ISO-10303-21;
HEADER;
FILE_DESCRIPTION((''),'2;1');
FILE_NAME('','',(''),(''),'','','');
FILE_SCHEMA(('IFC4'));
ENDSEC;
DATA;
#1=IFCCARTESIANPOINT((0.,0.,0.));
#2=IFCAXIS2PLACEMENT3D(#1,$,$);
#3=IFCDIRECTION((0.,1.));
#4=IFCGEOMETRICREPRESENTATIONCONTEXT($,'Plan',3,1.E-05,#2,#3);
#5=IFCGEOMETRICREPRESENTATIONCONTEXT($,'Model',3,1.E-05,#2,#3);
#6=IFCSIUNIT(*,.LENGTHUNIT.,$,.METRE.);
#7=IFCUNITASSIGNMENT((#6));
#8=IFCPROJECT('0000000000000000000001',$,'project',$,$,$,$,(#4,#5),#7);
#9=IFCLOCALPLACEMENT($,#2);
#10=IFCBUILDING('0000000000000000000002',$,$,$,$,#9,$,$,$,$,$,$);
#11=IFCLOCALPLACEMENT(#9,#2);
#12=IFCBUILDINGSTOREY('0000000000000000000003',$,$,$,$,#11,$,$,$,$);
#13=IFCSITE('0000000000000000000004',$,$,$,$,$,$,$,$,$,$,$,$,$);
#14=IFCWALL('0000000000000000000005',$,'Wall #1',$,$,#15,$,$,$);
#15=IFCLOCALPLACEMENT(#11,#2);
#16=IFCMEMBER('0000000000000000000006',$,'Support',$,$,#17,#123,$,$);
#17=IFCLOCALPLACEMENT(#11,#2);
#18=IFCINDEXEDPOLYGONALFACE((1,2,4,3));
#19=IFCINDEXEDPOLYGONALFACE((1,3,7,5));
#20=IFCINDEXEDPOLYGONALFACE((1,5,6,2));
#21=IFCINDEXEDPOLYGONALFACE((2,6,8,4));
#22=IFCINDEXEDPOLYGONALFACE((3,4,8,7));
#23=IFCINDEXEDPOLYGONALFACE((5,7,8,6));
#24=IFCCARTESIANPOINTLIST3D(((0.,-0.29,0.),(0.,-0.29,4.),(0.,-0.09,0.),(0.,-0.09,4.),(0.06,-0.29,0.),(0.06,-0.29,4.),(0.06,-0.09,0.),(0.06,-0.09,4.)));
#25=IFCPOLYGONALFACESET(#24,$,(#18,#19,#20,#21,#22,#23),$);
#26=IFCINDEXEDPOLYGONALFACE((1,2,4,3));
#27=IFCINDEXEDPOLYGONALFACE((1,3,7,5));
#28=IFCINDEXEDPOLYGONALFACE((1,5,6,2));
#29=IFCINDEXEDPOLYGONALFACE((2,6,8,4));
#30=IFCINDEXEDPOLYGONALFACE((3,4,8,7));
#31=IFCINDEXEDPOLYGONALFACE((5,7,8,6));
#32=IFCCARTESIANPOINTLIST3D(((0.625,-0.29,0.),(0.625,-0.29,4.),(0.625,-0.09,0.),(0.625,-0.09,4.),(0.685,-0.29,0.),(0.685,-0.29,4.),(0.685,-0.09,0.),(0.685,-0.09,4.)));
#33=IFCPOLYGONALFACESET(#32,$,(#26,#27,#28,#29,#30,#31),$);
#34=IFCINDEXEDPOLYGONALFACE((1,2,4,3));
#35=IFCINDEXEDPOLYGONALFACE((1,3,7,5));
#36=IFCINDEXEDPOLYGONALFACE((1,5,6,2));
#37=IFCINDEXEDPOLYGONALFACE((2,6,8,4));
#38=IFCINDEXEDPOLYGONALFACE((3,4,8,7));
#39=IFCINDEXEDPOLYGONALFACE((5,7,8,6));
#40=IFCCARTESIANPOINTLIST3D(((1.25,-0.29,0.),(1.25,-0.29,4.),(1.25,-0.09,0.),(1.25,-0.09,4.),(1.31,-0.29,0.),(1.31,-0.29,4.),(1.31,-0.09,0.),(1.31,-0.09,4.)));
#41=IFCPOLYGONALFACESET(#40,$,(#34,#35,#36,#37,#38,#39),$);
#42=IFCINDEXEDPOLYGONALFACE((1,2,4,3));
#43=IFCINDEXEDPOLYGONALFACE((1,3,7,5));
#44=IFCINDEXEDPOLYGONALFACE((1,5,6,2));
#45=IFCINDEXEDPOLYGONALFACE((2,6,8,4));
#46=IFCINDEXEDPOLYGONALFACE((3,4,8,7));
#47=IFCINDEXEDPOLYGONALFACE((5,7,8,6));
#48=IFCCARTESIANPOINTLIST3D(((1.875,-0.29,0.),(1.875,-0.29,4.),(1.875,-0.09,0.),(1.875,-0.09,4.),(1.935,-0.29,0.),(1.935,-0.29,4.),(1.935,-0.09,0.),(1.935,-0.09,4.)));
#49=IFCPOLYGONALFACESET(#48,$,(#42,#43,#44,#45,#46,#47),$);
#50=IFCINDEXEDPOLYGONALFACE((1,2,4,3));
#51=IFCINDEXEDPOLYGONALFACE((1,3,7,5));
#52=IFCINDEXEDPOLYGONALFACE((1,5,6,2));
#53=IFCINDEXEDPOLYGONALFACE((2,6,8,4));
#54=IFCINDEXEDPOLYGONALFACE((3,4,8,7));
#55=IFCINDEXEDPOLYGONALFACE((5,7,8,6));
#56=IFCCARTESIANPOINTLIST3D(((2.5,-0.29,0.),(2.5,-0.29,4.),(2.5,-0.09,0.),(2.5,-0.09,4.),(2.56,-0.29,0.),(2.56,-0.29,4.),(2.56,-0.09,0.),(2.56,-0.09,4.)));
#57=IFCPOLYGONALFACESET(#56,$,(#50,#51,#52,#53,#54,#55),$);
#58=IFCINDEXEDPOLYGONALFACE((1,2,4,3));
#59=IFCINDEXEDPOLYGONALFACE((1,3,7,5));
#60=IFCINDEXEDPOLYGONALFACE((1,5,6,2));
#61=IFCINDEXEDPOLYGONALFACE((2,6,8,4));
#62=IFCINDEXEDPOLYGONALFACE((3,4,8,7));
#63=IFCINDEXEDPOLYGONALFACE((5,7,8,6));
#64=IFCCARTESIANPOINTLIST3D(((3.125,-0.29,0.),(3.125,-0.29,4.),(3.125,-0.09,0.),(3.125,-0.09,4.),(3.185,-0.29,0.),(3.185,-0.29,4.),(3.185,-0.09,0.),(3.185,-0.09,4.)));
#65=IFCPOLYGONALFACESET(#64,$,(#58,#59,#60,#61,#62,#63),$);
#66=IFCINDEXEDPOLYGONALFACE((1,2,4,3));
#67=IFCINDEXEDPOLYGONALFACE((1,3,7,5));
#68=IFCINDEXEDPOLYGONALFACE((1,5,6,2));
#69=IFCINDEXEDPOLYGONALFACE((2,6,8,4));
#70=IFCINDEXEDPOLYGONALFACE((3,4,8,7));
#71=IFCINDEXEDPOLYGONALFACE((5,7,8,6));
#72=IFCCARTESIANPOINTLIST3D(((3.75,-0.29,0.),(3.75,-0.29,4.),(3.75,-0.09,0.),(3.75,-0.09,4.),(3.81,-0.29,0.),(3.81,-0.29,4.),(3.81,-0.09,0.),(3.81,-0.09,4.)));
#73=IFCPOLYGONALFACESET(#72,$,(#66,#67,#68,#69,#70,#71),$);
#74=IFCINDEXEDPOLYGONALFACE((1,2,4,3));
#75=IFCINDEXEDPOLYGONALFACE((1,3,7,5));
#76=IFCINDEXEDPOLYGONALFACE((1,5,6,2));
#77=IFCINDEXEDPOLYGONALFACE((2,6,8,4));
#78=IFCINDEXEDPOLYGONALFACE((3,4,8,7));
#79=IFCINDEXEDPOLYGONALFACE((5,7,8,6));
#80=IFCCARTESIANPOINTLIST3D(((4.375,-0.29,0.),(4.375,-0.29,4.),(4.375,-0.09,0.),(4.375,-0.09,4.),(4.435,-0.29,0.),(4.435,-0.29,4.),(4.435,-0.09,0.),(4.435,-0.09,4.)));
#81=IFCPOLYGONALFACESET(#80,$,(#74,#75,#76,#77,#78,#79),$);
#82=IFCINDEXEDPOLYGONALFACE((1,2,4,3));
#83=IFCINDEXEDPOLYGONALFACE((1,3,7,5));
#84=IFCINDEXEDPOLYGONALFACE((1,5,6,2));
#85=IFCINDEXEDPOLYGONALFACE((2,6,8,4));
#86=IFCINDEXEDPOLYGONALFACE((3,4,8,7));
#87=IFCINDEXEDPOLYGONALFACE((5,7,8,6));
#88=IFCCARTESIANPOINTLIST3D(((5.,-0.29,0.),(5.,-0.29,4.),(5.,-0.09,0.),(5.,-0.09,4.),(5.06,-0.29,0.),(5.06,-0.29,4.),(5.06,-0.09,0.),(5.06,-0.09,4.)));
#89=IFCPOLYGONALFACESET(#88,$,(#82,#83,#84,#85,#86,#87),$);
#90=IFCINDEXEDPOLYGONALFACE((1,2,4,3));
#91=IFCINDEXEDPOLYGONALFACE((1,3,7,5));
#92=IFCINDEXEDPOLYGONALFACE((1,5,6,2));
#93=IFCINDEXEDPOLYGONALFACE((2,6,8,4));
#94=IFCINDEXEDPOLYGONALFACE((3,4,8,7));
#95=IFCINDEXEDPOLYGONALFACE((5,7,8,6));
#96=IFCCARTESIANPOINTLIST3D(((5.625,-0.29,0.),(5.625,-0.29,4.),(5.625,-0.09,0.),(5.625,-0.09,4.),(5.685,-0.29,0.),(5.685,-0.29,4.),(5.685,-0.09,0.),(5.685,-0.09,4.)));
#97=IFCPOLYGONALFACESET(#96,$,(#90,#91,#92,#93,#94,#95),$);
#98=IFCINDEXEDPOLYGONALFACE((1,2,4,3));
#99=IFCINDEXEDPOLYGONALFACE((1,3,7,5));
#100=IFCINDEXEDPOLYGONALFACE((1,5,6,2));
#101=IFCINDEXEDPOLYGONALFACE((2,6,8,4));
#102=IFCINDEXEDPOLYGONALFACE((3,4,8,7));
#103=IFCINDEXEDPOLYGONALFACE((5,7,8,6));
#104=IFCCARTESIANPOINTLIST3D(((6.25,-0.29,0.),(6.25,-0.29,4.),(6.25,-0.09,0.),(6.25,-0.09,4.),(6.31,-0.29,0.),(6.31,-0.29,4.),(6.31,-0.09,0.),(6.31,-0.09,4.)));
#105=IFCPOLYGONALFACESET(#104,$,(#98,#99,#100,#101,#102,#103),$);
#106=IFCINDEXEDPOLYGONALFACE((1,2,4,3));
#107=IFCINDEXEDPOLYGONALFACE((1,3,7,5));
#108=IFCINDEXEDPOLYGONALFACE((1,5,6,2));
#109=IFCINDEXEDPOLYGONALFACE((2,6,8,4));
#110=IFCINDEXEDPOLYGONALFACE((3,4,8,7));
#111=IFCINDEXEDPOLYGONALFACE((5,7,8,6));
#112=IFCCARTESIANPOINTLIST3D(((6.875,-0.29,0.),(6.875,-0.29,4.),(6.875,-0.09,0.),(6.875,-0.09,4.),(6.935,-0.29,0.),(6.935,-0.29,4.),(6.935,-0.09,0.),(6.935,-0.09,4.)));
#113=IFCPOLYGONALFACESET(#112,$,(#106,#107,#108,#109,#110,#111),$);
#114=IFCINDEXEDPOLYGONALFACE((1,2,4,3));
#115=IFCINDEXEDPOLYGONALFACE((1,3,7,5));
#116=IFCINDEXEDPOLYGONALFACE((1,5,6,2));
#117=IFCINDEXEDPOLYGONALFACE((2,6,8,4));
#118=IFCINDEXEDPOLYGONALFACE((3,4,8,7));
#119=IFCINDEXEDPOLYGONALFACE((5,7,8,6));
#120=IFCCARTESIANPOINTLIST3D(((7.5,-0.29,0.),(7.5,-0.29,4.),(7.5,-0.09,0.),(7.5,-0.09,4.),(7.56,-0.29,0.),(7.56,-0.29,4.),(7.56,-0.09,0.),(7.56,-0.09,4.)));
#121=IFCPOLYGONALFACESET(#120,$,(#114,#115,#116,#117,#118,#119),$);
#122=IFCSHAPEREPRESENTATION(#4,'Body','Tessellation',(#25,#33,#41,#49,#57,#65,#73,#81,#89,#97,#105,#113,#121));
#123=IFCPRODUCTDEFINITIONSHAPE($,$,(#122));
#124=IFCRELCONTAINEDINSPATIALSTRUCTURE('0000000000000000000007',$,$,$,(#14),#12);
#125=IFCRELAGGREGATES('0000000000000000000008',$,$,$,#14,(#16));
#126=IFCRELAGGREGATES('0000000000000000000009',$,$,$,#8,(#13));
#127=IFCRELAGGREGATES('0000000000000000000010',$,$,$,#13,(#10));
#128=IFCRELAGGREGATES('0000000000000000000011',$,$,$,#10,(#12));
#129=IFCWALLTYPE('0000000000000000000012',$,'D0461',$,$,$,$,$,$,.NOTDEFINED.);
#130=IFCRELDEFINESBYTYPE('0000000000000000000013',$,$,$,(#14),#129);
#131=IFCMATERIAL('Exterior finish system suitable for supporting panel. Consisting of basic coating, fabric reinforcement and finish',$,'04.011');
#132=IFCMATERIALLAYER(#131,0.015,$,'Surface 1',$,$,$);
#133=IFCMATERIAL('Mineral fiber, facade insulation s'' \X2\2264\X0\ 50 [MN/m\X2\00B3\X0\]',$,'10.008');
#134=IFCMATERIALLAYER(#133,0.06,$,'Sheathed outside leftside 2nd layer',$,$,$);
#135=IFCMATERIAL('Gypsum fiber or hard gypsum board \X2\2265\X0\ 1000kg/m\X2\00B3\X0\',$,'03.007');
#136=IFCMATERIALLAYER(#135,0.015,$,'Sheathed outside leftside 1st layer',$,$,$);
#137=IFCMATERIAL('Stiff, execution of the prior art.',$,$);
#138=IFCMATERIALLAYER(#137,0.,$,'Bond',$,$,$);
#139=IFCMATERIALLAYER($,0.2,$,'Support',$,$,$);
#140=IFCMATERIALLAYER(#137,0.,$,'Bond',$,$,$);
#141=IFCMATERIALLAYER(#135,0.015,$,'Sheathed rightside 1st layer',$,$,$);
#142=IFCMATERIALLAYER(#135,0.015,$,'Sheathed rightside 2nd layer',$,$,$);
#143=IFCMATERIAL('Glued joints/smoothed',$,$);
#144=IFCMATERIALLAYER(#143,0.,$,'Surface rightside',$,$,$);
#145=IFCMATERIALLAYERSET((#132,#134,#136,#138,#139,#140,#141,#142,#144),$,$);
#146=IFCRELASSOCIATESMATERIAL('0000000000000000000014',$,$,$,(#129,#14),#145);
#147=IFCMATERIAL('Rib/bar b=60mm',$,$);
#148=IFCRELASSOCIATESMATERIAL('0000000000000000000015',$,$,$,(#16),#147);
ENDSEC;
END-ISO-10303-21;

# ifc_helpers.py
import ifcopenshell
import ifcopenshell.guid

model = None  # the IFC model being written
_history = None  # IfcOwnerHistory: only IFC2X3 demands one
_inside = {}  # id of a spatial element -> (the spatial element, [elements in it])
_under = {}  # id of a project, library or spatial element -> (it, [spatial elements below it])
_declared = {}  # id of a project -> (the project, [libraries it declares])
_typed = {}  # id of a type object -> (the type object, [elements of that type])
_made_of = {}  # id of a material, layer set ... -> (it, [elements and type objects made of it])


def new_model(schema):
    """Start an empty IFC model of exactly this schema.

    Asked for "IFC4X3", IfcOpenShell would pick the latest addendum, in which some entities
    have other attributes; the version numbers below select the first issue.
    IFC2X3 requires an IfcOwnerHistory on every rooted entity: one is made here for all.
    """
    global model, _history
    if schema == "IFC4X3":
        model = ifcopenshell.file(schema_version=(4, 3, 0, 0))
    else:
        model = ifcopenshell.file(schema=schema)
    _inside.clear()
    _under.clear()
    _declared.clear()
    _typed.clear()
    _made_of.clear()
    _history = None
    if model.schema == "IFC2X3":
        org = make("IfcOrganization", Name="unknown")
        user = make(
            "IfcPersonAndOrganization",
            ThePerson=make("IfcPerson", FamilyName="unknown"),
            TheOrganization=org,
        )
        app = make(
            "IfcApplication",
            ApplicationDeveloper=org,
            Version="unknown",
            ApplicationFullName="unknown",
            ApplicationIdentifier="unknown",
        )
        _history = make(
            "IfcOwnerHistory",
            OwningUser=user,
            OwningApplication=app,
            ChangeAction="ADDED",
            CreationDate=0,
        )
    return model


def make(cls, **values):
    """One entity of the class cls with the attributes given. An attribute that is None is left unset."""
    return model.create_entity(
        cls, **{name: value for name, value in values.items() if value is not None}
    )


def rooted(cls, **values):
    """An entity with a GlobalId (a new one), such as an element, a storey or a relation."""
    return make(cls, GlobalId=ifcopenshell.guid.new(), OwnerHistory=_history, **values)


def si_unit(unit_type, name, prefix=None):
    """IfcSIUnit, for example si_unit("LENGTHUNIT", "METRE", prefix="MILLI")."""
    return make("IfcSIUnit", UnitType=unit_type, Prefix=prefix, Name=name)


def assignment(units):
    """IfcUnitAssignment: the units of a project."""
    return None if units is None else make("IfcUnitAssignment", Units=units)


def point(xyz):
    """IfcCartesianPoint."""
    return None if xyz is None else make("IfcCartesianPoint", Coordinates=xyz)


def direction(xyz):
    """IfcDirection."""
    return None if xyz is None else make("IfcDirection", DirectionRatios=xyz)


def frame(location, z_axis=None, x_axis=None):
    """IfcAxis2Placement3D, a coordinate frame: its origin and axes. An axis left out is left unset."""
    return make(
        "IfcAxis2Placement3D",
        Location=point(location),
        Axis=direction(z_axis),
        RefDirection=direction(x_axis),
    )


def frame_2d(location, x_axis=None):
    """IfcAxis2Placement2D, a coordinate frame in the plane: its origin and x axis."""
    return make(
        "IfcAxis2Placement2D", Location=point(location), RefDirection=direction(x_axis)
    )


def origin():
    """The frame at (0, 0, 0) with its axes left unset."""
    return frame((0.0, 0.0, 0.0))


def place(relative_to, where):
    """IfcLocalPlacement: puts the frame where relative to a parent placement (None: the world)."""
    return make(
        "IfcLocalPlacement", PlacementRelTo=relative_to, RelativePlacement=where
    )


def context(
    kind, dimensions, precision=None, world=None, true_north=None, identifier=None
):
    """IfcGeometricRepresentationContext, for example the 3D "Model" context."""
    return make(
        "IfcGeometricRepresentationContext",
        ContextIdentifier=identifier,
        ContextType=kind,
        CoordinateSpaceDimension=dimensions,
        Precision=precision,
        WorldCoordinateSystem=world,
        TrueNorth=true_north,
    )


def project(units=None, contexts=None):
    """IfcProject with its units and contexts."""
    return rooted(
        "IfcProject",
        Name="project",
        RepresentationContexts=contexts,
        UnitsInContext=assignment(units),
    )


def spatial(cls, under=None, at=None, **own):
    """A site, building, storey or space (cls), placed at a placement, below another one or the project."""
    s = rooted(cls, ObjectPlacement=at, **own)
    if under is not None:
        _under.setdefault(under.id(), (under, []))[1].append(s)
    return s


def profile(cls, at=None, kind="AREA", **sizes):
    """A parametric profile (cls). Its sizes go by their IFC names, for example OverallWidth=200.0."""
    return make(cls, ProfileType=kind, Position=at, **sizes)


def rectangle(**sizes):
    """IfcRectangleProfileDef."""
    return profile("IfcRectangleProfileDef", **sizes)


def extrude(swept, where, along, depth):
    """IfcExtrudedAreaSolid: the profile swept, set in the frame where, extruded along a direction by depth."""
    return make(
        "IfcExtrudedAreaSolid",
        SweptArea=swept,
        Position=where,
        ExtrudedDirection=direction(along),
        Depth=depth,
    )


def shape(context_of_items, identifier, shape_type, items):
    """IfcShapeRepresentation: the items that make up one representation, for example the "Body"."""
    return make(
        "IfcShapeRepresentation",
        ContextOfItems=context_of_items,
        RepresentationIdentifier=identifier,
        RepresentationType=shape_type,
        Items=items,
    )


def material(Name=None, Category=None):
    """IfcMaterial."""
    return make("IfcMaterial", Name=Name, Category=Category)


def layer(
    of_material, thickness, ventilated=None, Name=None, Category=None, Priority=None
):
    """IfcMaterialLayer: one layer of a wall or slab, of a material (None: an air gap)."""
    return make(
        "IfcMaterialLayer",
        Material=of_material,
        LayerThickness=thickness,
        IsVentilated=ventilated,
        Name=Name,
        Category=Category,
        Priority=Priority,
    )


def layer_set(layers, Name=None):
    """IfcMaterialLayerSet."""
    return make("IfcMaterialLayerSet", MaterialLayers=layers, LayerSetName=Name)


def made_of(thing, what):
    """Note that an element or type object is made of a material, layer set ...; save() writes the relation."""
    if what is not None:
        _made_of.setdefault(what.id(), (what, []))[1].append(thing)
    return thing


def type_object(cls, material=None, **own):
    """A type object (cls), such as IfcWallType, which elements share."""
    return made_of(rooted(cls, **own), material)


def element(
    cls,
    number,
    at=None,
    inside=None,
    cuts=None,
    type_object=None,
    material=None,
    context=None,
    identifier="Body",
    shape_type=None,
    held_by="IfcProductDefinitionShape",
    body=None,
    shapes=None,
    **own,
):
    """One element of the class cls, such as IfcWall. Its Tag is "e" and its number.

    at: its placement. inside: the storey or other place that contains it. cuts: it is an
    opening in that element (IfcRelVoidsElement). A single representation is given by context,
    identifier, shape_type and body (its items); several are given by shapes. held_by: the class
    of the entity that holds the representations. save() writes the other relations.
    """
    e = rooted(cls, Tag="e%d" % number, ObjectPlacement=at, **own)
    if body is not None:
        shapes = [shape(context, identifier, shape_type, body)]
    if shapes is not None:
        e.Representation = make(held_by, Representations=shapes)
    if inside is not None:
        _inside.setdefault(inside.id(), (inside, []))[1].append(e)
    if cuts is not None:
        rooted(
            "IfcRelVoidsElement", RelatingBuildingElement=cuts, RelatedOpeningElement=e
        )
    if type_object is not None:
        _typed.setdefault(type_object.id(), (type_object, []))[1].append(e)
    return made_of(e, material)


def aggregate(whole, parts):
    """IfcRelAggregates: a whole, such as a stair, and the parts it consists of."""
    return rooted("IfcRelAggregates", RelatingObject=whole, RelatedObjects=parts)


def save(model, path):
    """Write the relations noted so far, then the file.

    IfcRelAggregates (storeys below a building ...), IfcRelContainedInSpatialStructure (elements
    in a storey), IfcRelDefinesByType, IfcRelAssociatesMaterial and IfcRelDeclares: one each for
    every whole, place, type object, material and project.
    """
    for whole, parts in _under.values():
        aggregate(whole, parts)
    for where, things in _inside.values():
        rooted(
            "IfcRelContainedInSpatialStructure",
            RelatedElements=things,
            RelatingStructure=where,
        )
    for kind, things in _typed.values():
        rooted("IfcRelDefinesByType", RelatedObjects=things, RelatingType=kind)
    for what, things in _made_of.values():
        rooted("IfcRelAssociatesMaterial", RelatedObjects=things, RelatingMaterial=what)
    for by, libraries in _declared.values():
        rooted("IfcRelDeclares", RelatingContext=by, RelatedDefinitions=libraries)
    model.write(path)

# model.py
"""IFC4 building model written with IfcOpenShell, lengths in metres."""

from ifc_helpers import new_model, si_unit, direction, frame, frame_2d, origin, place, context, project, spatial, rectangle, extrude, material, layer, layer_set, type_object, element, aggregate, save


model = new_model("IFC4")

# Units and contexts
plan_context = context("Plan", 3, precision=1e-05, world=origin(), true_north=direction((0.0, 1.0)))
model_context = context("Model", 3, precision=1e-05, world=origin(), true_north=direction((0.0, 1.0)))
ifc_project = project(units=[si_unit("LENGTHUNIT", "METRE")], contexts=[plan_context, model_context])

# Site, building, storey
site = spatial("IfcSite", under=ifc_project)
building_placement = place(None, origin())
building = spatial("IfcBuilding", under=site, at=building_placement)
storey_placement = place(building_placement, origin())
storey = spatial("IfcBuildingStorey", under=building, at=storey_placement)

# Wall, member
ifc_material_1 = material(Name="Exterior finish system suitable for supporting panel. Consisting of basic coating, fabric reinforcement and finish", Category="04.011")
ifc_layer_1 = layer(ifc_material_1, 0.015, Name="Surface 1")
ifc_material_2 = material(Name="Mineral fiber, facade insulation s' ≤ 50 [MN/m³]", Category="10.008")
ifc_layer_2 = layer(ifc_material_2, 0.06, Name="Sheathed outside leftside 2nd layer")
ifc_material_3 = material(Name="Gypsum fiber or hard gypsum board ≥ 1000kg/m³", Category="03.007")
ifc_layer_3 = layer(ifc_material_3, 0.015, Name="Sheathed outside leftside 1st layer")
ifc_material_4 = material(Name="Stiff, execution of the prior art.")
ifc_layer_4 = layer(ifc_material_4, 0.0, Name="Bond")
ifc_layer_5 = layer(None, 0.2, Name="Support")
ifc_layer_6 = layer(ifc_material_4, 0.0, Name="Bond")
ifc_layer_7 = layer(ifc_material_3, 0.015, Name="Sheathed rightside 1st layer")
ifc_layer_8 = layer(ifc_material_3, 0.015, Name="Sheathed rightside 2nd layer")
ifc_material_5 = material(Name="Glued joints/smoothed")
ifc_layer_9 = layer(ifc_material_5, 0.0, Name="Surface rightside")
ifc_layer_set = layer_set([ifc_layer_1, ifc_layer_2, ifc_layer_3, ifc_layer_4, ifc_layer_5, ifc_layer_6, ifc_layer_7, ifc_layer_8, ifc_layer_9])
wall_type = type_object("IfcWallType", Name="D0461", PredefinedType="NOTDEFINED", material=ifc_layer_set)
wall_placement = place(None, frame((0.0, 0.0, 0.0), z_axis=(0.0, -1.0, 0.0), x_axis=(1.0, 0.0, 0.0)))
wall = element("IfcWall", 1, at=wall_placement, inside=storey, type_object=wall_type, material=ifc_layer_set, Name="Wall #1")
ifc_material_6 = material(Name="Rib/bar b=60mm")
member_1_placement = place(wall_placement, origin())
member_1 = element("IfcMember", 2, at=member_1_placement, material=ifc_material_6, Name="Support", context=plan_context, shape_type="SweptSolid", body=[
    extrude(rectangle(XDim=0.06, YDim=0.2, at=frame_2d((0.03, 0.1), x_axis=(1.0, 0.0))), frame((0.0, 4.0, 0.09), z_axis=(0.0, -1.0, 0.0), x_axis=(1.0, 0.0, 0.0)), (0.0, 0.0, 1.0), 4.0),
    extrude(rectangle(XDim=0.06, YDim=0.2, at=frame_2d((0.03, 0.1), x_axis=(1.0, 0.0))), frame((0.625, 4.0, 0.09), z_axis=(0.0, -1.0, 0.0), x_axis=(1.0, 0.0, 0.0)), (0.0, 0.0, 1.0), 4.0),
    extrude(rectangle(XDim=0.06, YDim=0.2, at=frame_2d((0.03, 0.1), x_axis=(1.0, 0.0))), frame((1.25, 4.0, 0.09), z_axis=(0.0, -1.0, 0.0), x_axis=(1.0, 0.0, 0.0)), (0.0, 0.0, 1.0), 4.0),
    extrude(rectangle(XDim=0.06, YDim=0.2, at=frame_2d((0.03, 0.1), x_axis=(1.0, 0.0))), frame((1.875, 4.0, 0.09), z_axis=(0.0, -1.0, 0.0), x_axis=(1.0, 0.0, 0.0)), (0.0, 0.0, 1.0), 4.0),
    extrude(rectangle(XDim=0.06, YDim=0.2, at=frame_2d((0.03, 0.1), x_axis=(1.0, 0.0))), frame((2.5, 4.0, 0.09), z_axis=(0.0, -1.0, 0.0), x_axis=(1.0, 0.0, 0.0)), (0.0, 0.0, 1.0), 4.0),
    extrude(rectangle(XDim=0.06, YDim=0.2, at=frame_2d((0.03, 0.1), x_axis=(1.0, 0.0))), frame((3.125, 4.0, 0.09), z_axis=(0.0, -1.0, 0.0), x_axis=(1.0, 0.0, 0.0)), (0.0, 0.0, 1.0), 4.0),
    extrude(rectangle(XDim=0.06, YDim=0.2, at=frame_2d((0.03, 0.1), x_axis=(1.0, 0.0))), frame((3.75, 4.0, 0.09), z_axis=(0.0, -1.0, 0.0), x_axis=(1.0, 0.0, 0.0)), (0.0, 0.0, 1.0), 4.0),
    extrude(rectangle(XDim=0.06, YDim=0.2, at=frame_2d((0.03, 0.1), x_axis=(1.0, 0.0))), frame((4.375, 4.0, 0.09), z_axis=(0.0, -1.0, 0.0), x_axis=(1.0, 0.0, 0.0)), (0.0, 0.0, 1.0), 4.0),
    extrude(rectangle(XDim=0.06, YDim=0.2, at=frame_2d((0.03, 0.1), x_axis=(1.0, 0.0))), frame((5.0, 4.0, 0.09), z_axis=(0.0, -1.0, 0.0), x_axis=(1.0, 0.0, 0.0)), (0.0, 0.0, 1.0), 4.0),
    extrude(rectangle(XDim=0.06, YDim=0.2, at=frame_2d((0.03, 0.1), x_axis=(1.0, 0.0))), frame((5.625, 4.0, 0.09), z_axis=(0.0, -1.0, 0.0), x_axis=(1.0, 0.0, 0.0)), (0.0, 0.0, 1.0), 4.0),
    extrude(rectangle(XDim=0.06, YDim=0.2, at=frame_2d((0.03, 0.1), x_axis=(1.0, 0.0))), frame((6.25, 4.0, 0.09), z_axis=(0.0, -1.0, 0.0), x_axis=(1.0, 0.0, 0.0)), (0.0, 0.0, 1.0), 4.0),
    extrude(rectangle(XDim=0.06, YDim=0.2, at=frame_2d((0.03, 0.1), x_axis=(1.0, 0.0))), frame((6.875, 4.0, 0.09), z_axis=(0.0, -1.0, 0.0), x_axis=(1.0, 0.0, 0.0)), (0.0, 0.0, 1.0), 4.0),
    extrude(rectangle(XDim=0.06, YDim=0.2, at=frame_2d((0.03, 0.1), x_axis=(1.0, 0.0))), frame((7.5, 4.0, 0.09), z_axis=(0.0, -1.0, 0.0), x_axis=(1.0, 0.0, 0.0)), (0.0, 0.0, 1.0), 4.0),
])
aggregate(wall, [member_1])

save(model, "model.ifc")
